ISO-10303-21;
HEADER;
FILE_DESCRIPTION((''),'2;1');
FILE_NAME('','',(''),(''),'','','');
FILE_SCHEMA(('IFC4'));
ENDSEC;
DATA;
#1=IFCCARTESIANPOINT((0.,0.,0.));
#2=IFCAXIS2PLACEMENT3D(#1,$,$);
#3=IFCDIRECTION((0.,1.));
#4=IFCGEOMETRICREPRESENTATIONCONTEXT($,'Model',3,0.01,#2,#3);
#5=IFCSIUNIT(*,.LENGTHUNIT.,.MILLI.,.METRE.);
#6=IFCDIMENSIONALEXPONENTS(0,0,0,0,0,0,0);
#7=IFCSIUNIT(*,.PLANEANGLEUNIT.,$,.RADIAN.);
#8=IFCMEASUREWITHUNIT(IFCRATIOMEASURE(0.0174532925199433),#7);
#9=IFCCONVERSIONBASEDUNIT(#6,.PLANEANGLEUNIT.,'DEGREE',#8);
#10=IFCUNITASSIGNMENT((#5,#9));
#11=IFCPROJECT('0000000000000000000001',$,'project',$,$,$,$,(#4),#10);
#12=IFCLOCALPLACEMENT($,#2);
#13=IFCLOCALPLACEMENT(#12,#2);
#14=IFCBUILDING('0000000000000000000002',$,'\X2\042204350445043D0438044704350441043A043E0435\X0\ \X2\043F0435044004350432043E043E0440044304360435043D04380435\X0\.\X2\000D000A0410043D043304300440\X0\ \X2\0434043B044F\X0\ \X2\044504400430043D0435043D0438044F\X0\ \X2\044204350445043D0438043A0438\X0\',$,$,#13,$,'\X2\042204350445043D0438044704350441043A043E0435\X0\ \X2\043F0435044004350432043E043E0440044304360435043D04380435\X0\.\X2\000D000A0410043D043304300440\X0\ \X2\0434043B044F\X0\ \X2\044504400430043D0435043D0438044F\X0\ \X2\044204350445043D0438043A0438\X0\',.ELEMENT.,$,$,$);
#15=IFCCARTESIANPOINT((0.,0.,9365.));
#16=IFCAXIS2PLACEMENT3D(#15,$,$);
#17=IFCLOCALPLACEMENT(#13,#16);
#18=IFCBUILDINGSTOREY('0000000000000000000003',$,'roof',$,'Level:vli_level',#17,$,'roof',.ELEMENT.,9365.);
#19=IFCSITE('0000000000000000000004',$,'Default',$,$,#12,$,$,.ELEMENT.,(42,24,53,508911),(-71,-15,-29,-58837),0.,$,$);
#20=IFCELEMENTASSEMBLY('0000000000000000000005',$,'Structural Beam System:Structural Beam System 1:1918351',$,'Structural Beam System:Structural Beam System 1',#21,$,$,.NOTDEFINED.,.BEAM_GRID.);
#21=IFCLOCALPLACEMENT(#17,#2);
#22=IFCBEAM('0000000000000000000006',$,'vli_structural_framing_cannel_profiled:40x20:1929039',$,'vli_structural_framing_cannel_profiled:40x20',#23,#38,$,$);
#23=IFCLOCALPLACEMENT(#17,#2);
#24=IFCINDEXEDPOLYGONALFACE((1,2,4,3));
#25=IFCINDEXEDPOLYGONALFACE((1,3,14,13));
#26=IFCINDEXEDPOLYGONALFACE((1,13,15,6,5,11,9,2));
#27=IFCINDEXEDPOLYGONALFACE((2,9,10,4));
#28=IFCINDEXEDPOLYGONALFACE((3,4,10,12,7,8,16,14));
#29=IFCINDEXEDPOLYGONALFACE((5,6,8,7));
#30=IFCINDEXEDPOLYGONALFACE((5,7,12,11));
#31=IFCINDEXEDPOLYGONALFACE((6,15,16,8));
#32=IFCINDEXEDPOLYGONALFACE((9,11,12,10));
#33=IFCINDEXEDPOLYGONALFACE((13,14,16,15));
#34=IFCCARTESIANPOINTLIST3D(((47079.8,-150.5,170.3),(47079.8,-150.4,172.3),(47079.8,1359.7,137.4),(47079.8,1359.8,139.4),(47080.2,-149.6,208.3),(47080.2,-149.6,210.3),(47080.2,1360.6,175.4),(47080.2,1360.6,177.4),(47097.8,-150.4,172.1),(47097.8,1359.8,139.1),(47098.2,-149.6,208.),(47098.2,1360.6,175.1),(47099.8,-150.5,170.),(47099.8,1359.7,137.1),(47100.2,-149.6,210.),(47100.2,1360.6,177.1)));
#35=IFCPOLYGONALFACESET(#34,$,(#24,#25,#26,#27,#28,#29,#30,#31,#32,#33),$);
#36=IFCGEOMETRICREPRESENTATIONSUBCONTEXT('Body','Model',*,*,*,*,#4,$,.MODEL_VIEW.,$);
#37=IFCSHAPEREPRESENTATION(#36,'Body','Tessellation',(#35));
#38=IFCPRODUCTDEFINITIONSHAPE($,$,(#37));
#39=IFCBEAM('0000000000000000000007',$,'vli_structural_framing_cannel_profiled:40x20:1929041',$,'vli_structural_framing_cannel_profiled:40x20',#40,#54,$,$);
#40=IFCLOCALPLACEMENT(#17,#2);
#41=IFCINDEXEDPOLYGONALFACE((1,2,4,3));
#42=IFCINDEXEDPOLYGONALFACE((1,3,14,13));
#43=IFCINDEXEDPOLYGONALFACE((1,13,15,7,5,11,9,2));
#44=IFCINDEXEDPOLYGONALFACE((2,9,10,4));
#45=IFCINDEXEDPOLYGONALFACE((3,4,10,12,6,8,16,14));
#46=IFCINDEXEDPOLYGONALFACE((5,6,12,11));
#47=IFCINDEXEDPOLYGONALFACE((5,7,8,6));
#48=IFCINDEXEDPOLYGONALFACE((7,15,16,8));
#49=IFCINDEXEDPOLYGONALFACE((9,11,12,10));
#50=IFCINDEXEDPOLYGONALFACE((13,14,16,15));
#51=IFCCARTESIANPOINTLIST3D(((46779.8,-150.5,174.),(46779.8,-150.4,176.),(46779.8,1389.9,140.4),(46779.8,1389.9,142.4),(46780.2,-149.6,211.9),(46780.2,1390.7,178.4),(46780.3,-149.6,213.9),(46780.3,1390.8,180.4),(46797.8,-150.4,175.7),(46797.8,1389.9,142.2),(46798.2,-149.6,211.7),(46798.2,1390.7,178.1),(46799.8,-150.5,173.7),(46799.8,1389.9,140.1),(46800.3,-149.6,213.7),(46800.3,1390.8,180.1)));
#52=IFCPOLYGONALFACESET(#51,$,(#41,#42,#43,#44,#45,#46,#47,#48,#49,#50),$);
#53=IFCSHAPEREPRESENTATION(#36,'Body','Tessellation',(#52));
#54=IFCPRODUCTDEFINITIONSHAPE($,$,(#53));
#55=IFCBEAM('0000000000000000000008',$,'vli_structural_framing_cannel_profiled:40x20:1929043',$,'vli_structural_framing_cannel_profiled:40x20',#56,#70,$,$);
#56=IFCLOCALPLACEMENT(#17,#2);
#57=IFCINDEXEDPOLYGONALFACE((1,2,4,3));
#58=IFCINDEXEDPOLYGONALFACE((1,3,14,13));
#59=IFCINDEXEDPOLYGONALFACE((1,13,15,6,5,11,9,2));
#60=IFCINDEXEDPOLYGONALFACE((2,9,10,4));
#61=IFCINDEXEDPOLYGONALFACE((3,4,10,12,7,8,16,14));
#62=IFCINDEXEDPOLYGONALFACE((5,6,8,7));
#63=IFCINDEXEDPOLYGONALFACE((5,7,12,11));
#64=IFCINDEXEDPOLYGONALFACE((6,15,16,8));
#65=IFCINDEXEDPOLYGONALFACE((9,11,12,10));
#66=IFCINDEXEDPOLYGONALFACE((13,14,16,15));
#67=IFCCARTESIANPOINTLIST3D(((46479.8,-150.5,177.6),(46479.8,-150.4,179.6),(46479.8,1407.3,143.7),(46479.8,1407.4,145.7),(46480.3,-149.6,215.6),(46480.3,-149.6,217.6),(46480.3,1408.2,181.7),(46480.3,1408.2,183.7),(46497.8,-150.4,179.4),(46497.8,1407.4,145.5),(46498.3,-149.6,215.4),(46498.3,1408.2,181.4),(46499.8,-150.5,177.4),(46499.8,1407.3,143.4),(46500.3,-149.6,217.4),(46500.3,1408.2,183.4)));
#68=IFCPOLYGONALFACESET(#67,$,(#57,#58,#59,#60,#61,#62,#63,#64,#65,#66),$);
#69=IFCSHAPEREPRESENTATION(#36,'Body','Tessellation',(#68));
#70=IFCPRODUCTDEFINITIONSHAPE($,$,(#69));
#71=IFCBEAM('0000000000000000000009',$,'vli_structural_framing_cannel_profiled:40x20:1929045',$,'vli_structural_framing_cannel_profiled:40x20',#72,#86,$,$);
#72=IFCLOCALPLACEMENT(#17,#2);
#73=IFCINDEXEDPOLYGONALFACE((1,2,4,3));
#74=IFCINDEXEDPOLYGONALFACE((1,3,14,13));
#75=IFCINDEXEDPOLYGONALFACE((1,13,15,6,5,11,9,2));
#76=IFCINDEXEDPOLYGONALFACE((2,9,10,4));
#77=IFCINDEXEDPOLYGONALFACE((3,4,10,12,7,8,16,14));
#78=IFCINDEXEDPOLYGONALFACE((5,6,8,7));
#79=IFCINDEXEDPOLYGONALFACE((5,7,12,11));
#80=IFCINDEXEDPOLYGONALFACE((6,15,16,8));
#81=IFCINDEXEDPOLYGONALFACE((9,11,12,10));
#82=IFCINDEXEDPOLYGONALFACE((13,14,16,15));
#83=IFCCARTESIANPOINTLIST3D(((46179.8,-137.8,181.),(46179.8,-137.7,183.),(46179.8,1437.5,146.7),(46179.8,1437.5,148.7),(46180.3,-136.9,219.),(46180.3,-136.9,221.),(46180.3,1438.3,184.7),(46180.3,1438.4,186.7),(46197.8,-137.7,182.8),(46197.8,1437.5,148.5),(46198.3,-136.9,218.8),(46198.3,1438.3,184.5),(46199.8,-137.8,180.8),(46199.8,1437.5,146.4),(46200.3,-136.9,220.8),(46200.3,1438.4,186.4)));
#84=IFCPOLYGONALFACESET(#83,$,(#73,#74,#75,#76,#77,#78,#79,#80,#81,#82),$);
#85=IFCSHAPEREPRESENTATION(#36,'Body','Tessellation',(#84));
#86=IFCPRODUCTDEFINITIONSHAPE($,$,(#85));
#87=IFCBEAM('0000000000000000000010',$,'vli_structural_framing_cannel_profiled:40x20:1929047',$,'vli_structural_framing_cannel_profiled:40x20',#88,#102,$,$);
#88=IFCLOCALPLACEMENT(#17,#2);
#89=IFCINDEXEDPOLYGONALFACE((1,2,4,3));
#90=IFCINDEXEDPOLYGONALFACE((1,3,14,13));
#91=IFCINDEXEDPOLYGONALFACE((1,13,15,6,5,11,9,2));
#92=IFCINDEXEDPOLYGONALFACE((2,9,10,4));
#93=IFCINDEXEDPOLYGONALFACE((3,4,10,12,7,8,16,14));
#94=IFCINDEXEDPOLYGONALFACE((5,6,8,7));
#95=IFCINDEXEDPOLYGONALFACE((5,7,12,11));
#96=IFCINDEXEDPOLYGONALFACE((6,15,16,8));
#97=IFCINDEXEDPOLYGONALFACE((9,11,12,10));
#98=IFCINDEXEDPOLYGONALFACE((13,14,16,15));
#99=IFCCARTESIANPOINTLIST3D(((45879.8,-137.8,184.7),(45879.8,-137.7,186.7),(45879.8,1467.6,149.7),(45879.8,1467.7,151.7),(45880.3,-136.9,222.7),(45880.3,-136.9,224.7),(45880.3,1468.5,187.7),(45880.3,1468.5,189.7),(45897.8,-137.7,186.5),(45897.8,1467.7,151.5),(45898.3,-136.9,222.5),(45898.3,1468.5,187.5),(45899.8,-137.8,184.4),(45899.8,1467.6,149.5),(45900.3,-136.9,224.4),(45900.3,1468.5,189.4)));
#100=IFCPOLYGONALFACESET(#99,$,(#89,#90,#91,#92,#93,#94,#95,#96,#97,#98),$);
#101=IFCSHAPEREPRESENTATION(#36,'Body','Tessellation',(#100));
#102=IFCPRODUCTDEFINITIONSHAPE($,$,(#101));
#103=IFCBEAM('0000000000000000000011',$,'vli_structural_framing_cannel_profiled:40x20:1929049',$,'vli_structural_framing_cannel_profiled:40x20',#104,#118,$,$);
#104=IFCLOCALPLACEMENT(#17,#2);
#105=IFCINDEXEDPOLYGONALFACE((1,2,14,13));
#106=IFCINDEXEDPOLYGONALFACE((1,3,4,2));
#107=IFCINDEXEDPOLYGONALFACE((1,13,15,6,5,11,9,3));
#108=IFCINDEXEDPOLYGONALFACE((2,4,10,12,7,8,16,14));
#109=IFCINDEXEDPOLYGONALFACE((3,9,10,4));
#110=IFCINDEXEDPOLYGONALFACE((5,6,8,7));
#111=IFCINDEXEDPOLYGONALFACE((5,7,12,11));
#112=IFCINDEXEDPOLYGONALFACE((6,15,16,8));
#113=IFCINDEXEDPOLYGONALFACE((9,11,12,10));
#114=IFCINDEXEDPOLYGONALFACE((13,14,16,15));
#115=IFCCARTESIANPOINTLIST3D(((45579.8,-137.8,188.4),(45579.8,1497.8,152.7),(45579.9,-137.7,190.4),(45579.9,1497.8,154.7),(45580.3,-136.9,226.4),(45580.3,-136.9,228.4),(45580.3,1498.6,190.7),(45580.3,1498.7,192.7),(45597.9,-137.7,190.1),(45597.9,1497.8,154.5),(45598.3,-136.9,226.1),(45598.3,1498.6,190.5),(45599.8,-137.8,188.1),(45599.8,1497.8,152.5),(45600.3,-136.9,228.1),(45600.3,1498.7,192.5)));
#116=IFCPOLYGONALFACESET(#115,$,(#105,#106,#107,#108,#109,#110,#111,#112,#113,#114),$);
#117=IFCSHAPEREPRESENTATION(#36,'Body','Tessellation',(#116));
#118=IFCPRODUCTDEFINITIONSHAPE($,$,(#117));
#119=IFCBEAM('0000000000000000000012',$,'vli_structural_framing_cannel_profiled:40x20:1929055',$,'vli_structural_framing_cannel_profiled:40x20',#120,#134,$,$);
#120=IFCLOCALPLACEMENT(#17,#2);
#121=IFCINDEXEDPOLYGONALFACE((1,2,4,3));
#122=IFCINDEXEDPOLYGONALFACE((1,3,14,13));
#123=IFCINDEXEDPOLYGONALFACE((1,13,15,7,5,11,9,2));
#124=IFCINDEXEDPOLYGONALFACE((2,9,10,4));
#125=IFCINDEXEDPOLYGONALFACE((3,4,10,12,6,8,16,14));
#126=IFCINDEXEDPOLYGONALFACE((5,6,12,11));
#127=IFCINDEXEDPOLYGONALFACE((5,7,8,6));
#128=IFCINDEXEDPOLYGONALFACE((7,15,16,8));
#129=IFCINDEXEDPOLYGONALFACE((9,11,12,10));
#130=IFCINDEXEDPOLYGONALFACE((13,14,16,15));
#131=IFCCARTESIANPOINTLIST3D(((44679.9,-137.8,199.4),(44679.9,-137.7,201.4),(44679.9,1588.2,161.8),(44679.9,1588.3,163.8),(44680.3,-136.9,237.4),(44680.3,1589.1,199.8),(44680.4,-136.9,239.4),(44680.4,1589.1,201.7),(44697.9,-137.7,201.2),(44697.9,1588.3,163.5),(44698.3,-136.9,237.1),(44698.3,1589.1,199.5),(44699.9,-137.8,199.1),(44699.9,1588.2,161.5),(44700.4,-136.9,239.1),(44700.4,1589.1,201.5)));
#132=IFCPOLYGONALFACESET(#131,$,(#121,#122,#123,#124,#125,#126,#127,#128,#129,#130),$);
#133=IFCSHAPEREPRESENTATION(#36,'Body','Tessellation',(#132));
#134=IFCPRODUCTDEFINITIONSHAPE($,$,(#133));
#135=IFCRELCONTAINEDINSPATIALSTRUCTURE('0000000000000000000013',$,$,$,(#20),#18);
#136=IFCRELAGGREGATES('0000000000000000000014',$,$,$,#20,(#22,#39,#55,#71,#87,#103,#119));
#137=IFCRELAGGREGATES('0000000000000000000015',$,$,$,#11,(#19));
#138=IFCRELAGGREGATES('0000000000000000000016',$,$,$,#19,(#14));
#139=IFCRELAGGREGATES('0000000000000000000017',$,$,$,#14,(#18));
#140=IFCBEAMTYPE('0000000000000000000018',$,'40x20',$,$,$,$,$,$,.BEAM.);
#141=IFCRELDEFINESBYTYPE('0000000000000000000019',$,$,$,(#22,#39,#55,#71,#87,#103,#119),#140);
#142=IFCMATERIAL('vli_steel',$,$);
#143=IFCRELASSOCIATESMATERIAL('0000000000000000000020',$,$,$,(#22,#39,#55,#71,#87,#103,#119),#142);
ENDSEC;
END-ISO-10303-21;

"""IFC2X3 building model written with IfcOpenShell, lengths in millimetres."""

from ifc_helpers import new_model, entity, si_unit, converted_unit, direction, frame, origin, place, context, subcontext, project, spatial, polyline, outline, extrude, material, type_object, element, aggregate, save


model = new_model("IFC2X3")

# Units and contexts
model_context = context("Model", 3, precision=0.01, world=origin(), true_north=direction((0.0, 1.0)))
body_context = subcontext(model_context, "Body", "Model", "MODEL_VIEW")
ifc_project = project(units=[si_unit("LENGTHUNIT", "METRE", prefix="MILLI"), converted_unit("PLANEANGLEUNIT", "DEGREE", entity("IfcRatioMeasure", 0.0174532925199433), si_unit("PLANEANGLEUNIT", "RADIAN"), dimensions=[0, 0, 0, 0, 0, 0, 0])], contexts=[model_context])

# Site, building, storey
site_placement = place(None, origin())
site = spatial("IfcSite", under=ifc_project, at=site_placement, Name="Default", CompositionType="ELEMENT", RefLatitude=(42, 24, 53, 508911), RefLongitude=(-71, -15, -29, -58837), RefElevation=0.0)
building_placement = place(site_placement, origin())
building = spatial("IfcBuilding", under=site, at=building_placement, Name="Техническое перевооружение.\r\nАнгар для хранения техники", LongName="Техническое перевооружение.\r\nАнгар для хранения техники", CompositionType="ELEMENT")
storey_placement = place(building_placement, frame((0.0, 0.0, 9365.0)))
storey = spatial("IfcBuildingStorey", under=building, at=storey_placement, Name="roof", ObjectType="Level:vli_level", LongName="roof", CompositionType="ELEMENT", Elevation=9365.0)

# Element assembly, beams
ifc_material = material(Name="vli_steel")
beam_type = type_object("IfcBeamType", Name="40x20", PredefinedType="BEAM")
assembly_1_placement = place(storey_placement, origin())
assembly_1 = element("IfcElementAssembly", 1, at=assembly_1_placement, inside=storey, Name="Structural Beam System:Structural Beam System 1:1918351", ObjectType="Structural Beam System:Structural Beam System 1", AssemblyPlace="NOTDEFINED", PredefinedType="BEAM_GRID")
beam_1_placement = place(assembly_1_placement, frame((47099.6, 1361.3, 177.1), z_axis=(0.0, 0.02179, 0.999763), x_axis=(0.0, -0.999763, 0.02179)))
beam_1 = element("IfcBeam", 2, at=beam_1_placement, type_object=beam_type, material=ifc_material, Name="vli_structural_framing_cannel_profiled:40x20:1929039", ObjectType="vli_structural_framing_cannel_profiled:40x20", context=body_context, shape_type="SweptSolid", body=[
    extrude(outline(polyline([(-10.5, -20.0), (9.5, -20.0), (9.5, -18.0), (-8.5, -18.0), (-8.5, 18.0), (9.5, 18.0), (9.5, 20.0), (-10.5, 20.0), (-10.5, -20.0)])), frame((0.7, -10.1, -19.9), z_axis=(1.0, 0.0, 0.0), x_axis=(0.0, -0.999925, 0.012243)), (0.0, 0.0, 1.0), 1510.6),
])
beam_2_placement = place(assembly_1_placement, frame((46799.7, 1391.4, 180.1), z_axis=(0.0, 0.02179, 0.999763), x_axis=(0.0, -0.999763, 0.02179)))
beam_2 = element("IfcBeam", 3, at=beam_2_placement, type_object=beam_type, material=ifc_material, Name="vli_structural_framing_cannel_profiled:40x20:1929041", ObjectType="vli_structural_framing_cannel_profiled:40x20", context=body_context, shape_type="SweptSolid", body=[
    extrude(outline(polyline([(-10.5, -20.0), (9.5, -20.0), (9.5, -18.0), (-8.5, -18.0), (-8.5, 18.0), (9.5, 18.0), (9.5, 20.0), (-10.5, 20.0), (-10.5, -20.0)])), frame((0.7, -10.1, -19.9), z_axis=(1.0, 0.0, 0.0), x_axis=(0.0, -0.999925, 0.012243)), (0.0, 0.0, 1.0), 1540.7),
])
beam_3_placement = place(assembly_1_placement, frame((46499.7, 1421.6, 183.1), z_axis=(0.0, 0.02179, 0.999763), x_axis=(0.0, -0.999763, 0.02179)))
beam_3 = element("IfcBeam", 4, at=beam_3_placement, type_object=beam_type, material=ifc_material, Name="vli_structural_framing_cannel_profiled:40x20:1929043", ObjectType="vli_structural_framing_cannel_profiled:40x20", context=body_context, shape_type="SweptSolid", body=[
    extrude(outline(polyline([(-10.5, -20.0), (9.5, -20.0), (9.5, -18.0), (-8.5, -18.0), (-8.5, 18.0), (9.5, 18.0), (9.5, 20.0), (-10.5, 20.0), (-10.5, -20.0)])), frame((13.4, -10.1, -19.9), z_axis=(1.0, 0.0, 0.0), x_axis=(0.0, -0.999925, 0.012243)), (0.0, 0.0, 1.0), 1558.2),
])
beam_4_placement = place(assembly_1_placement, frame((46199.7, 1451.7, 186.1), z_axis=(0.0, 0.02179, 0.999763), x_axis=(0.0, -0.999763, 0.02179)))
beam_4 = element("IfcBeam", 5, at=beam_4_placement, type_object=beam_type, material=ifc_material, Name="vli_structural_framing_cannel_profiled:40x20:1929045", ObjectType="vli_structural_framing_cannel_profiled:40x20", context=body_context, shape_type="SweptSolid", body=[
    extrude(outline(polyline([(-10.5, -20.0), (9.5, -20.0), (9.5, -18.0), (-8.5, -18.0), (-8.5, 18.0), (9.5, 18.0), (9.5, 20.0), (-10.5, 20.0), (-10.5, -20.0)])), frame((13.4, -10.1, -19.9), z_axis=(1.0, 0.0, 0.0), x_axis=(0.0, -0.999925, 0.012243)), (0.0, 0.0, 1.0), 1575.6),
])
beam_5_placement = place(assembly_1_placement, frame((45899.7, 1481.9, 189.2), z_axis=(0.0, 0.02179, 0.999763), x_axis=(0.0, -0.999763, 0.02179)))
beam_5 = element("IfcBeam", 6, at=beam_5_placement, type_object=beam_type, material=ifc_material, Name="vli_structural_framing_cannel_profiled:40x20:1929047", ObjectType="vli_structural_framing_cannel_profiled:40x20", context=body_context, shape_type="SweptSolid", body=[
    extrude(outline(polyline([(-10.5, -20.0), (9.5, -20.0), (9.5, -18.0), (-8.5, -18.0), (-8.5, 18.0), (9.5, 18.0), (9.5, 20.0), (-10.5, 20.0), (-10.5, -20.0)])), frame((13.4, -10.1, -19.9), z_axis=(1.0, 0.0, 0.0), x_axis=(0.0, -0.999925, 0.012243)), (0.0, 0.0, 1.0), 1605.8),
])
beam_6_placement = place(assembly_1_placement, frame((45599.7, 1512.0, 192.2), z_axis=(0.0, 0.02179, 0.999763), x_axis=(0.0, -0.999763, 0.02179)))
beam_6 = element("IfcBeam", 7, at=beam_6_placement, type_object=beam_type, material=ifc_material, Name="vli_structural_framing_cannel_profiled:40x20:1929049", ObjectType="vli_structural_framing_cannel_profiled:40x20", context=body_context, shape_type="SweptSolid", body=[
    extrude(outline(polyline([(-10.5, -20.0), (9.5, -20.0), (9.5, -18.0), (-8.5, -18.0), (-8.5, 18.0), (9.5, 18.0), (9.5, 20.0), (-10.5, 20.0), (-10.5, -20.0)])), frame((13.4, -10.1, -19.9), z_axis=(1.0, 0.0, 0.0), x_axis=(0.0, -0.999925, 0.012243)), (0.0, 0.0, 1.0), 1635.9),
])
beam_7_placement = place(assembly_1_placement, frame((44699.8, 1602.5, 201.2), z_axis=(0.0, 0.02179, 0.999763), x_axis=(0.0, -0.999763, 0.02179)))
beam_7 = element("IfcBeam", 8, at=beam_7_placement, type_object=beam_type, material=ifc_material, Name="vli_structural_framing_cannel_profiled:40x20:1929055", ObjectType="vli_structural_framing_cannel_profiled:40x20", context=body_context, shape_type="SweptSolid", body=[
    extrude(outline(polyline([(-10.5, -20.0), (9.5, -20.0), (9.5, -18.0), (-8.5, -18.0), (-8.5, 18.0), (9.5, 18.0), (9.5, 20.0), (-10.5, 20.0), (-10.5, -20.0)])), frame((13.4, -10.1, -19.9), z_axis=(1.0, 0.0, 0.0), x_axis=(0.0, -0.999925, 0.012243)), (0.0, 0.0, 1.0), 1726.4),
])
aggregate(assembly_1, [beam_1, beam_2, beam_3, beam_4, beam_5, beam_6, beam_7])

save(model, "model.ifc")
